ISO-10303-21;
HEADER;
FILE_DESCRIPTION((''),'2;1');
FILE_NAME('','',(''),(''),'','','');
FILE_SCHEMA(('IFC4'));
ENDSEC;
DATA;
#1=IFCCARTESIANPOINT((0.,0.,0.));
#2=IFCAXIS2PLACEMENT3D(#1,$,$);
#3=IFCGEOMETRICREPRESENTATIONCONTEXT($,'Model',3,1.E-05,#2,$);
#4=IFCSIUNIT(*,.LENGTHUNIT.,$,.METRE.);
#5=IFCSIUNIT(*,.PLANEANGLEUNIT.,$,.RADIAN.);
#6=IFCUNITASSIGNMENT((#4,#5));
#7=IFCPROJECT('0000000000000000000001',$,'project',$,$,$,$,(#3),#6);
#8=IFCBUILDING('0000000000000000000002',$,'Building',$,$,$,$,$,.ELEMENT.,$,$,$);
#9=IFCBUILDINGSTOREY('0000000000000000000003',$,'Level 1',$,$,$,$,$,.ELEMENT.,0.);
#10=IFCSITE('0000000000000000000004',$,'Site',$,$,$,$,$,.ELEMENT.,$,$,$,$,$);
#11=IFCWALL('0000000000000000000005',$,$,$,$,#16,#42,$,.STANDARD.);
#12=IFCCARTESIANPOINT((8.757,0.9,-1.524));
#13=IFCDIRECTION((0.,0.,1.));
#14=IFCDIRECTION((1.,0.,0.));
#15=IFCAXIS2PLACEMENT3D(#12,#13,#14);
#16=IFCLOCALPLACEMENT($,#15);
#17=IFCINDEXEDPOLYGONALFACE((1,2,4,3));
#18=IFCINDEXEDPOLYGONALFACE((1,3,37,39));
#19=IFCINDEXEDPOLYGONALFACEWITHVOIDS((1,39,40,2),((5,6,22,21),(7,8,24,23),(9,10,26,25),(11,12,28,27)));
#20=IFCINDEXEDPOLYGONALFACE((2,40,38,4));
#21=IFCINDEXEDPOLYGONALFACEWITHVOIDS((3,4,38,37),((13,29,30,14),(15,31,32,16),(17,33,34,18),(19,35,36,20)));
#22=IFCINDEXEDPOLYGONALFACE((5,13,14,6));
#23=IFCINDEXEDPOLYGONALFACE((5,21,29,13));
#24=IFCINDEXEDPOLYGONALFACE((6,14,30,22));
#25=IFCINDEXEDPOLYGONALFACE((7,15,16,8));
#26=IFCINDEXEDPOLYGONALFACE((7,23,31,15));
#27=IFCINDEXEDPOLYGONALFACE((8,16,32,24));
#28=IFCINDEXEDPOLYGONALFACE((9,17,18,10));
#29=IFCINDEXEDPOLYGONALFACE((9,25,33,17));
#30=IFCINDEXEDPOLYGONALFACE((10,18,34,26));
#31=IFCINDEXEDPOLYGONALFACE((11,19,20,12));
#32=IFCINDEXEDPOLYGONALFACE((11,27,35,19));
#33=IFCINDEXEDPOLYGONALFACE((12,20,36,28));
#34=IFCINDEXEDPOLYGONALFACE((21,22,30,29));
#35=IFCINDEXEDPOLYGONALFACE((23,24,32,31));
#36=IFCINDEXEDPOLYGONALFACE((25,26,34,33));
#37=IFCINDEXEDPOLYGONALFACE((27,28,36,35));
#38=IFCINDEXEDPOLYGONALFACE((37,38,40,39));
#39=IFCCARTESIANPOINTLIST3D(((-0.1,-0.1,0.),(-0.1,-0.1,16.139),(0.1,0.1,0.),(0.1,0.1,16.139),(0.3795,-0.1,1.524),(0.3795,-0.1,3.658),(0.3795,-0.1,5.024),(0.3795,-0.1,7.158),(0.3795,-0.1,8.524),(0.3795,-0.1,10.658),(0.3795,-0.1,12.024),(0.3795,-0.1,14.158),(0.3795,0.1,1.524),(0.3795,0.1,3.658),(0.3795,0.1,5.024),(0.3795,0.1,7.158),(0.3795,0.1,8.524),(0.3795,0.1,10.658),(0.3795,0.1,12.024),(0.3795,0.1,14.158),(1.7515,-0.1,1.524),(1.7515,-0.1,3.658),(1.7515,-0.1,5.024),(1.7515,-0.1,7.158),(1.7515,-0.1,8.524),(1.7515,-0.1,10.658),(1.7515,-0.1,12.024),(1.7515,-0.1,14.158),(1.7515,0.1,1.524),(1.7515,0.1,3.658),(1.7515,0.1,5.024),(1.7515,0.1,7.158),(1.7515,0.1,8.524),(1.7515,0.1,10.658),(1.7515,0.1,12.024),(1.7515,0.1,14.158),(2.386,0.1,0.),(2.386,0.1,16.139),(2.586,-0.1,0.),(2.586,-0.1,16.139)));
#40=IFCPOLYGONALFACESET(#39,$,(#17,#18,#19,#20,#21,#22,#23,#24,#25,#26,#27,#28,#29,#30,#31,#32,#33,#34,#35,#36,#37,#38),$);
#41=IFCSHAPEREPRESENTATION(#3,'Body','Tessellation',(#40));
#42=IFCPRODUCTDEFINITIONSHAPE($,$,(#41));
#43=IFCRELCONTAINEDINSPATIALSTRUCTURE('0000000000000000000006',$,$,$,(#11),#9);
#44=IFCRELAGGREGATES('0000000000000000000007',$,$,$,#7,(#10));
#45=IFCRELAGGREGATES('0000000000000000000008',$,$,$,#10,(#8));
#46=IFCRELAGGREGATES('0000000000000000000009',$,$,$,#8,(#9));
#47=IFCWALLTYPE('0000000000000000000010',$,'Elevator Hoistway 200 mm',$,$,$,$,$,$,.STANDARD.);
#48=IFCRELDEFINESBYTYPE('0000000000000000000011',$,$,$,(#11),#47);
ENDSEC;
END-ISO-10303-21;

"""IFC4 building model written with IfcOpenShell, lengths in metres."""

from ifc_helpers import new_model, si_unit, frame, origin, origin_2d, place, context, project, spatial, polyline, rectangle, outline, extrude, type_object, element, save


model = new_model("IFC4")

# Units and contexts
model_context = context("Model", 3, precision=1e-05, world=origin())
ifc_project = project(units=[si_unit("LENGTHUNIT", "METRE"), si_unit("PLANEANGLEUNIT", "RADIAN")], contexts=[model_context])

# Site, building, storey
site = spatial("IfcSite", under=ifc_project, Name="Site", CompositionType="ELEMENT")
building = spatial("IfcBuilding", under=site, Name="Building", CompositionType="ELEMENT")
storey = spatial("IfcBuildingStorey", under=building, Name="Level 1", CompositionType="ELEMENT", Elevation=0.0)

# Shared definitions
wall_type = type_object("IfcWallType", Name="Elevator Hoistway 200 mm", PredefinedType="STANDARD")

# Wall, openings
wall_1_placement = place(None, frame((8.757, 0.9, -1.524), z_axis=(0.0, 0.0, 1.0), x_axis=(1.0, 0.0, 0.0)))
wall_1 = element("IfcWall", 1, at=wall_1_placement, inside=storey, type_object=wall_type, PredefinedType="STANDARD", context=model_context, shape_type="SweptSolid", body=[
    extrude(outline(polyline([(-0.1, -0.1), (2.586, -0.1), (2.386, 0.1), (0.1, 0.1), (-0.1, -0.1)])), origin(), (0.0, 0.0, 1.0), 16.139),
])
opening_1_placement = place(wall_1_placement, frame((1.0655, 0.0, 1.524), z_axis=(0.0, 0.0, 1.0), x_axis=(1.0, 0.0, 0.0)))
element("IfcOpeningElement", 2, at=opening_1_placement, cuts=wall_1, PredefinedType="OPENING", context=model_context, shape_type="SweptSolid", body=[
    extrude(rectangle(XDim=1.372, YDim=0.202, at=origin_2d()), origin(), (0.0, 0.0, 1.0), 2.134),
])
opening_2_placement = place(wall_1_placement, frame((1.0655, 0.0, 5.024), z_axis=(0.0, 0.0, 1.0), x_axis=(1.0, 0.0, 0.0)))
element("IfcOpeningElement", 3, at=opening_2_placement, cuts=wall_1, PredefinedType="OPENING", context=model_context, shape_type="SweptSolid", body=[
    extrude(rectangle(XDim=1.372, YDim=0.202, at=origin_2d()), origin(), (0.0, 0.0, 1.0), 2.134),
])
opening_3_placement = place(wall_1_placement, frame((1.0655, 0.0, 8.524), z_axis=(0.0, 0.0, 1.0), x_axis=(1.0, 0.0, 0.0)))
element("IfcOpeningElement", 4, at=opening_3_placement, cuts=wall_1, PredefinedType="OPENING", context=model_context, shape_type="SweptSolid", body=[
    extrude(rectangle(XDim=1.372, YDim=0.202, at=origin_2d()), origin(), (0.0, 0.0, 1.0), 2.134),
])
opening_4_placement = place(wall_1_placement, frame((1.0655, 0.0, 12.024), z_axis=(0.0, 0.0, 1.0), x_axis=(1.0, 0.0, 0.0)))
element("IfcOpeningElement", 5, at=opening_4_placement, cuts=wall_1, PredefinedType="OPENING", context=model_context, shape_type="SweptSolid", body=[
    extrude(rectangle(XDim=1.372, YDim=0.202, at=origin_2d()), origin(), (0.0, 0.0, 1.0), 2.134),
])

save(model, "model.ifc")
